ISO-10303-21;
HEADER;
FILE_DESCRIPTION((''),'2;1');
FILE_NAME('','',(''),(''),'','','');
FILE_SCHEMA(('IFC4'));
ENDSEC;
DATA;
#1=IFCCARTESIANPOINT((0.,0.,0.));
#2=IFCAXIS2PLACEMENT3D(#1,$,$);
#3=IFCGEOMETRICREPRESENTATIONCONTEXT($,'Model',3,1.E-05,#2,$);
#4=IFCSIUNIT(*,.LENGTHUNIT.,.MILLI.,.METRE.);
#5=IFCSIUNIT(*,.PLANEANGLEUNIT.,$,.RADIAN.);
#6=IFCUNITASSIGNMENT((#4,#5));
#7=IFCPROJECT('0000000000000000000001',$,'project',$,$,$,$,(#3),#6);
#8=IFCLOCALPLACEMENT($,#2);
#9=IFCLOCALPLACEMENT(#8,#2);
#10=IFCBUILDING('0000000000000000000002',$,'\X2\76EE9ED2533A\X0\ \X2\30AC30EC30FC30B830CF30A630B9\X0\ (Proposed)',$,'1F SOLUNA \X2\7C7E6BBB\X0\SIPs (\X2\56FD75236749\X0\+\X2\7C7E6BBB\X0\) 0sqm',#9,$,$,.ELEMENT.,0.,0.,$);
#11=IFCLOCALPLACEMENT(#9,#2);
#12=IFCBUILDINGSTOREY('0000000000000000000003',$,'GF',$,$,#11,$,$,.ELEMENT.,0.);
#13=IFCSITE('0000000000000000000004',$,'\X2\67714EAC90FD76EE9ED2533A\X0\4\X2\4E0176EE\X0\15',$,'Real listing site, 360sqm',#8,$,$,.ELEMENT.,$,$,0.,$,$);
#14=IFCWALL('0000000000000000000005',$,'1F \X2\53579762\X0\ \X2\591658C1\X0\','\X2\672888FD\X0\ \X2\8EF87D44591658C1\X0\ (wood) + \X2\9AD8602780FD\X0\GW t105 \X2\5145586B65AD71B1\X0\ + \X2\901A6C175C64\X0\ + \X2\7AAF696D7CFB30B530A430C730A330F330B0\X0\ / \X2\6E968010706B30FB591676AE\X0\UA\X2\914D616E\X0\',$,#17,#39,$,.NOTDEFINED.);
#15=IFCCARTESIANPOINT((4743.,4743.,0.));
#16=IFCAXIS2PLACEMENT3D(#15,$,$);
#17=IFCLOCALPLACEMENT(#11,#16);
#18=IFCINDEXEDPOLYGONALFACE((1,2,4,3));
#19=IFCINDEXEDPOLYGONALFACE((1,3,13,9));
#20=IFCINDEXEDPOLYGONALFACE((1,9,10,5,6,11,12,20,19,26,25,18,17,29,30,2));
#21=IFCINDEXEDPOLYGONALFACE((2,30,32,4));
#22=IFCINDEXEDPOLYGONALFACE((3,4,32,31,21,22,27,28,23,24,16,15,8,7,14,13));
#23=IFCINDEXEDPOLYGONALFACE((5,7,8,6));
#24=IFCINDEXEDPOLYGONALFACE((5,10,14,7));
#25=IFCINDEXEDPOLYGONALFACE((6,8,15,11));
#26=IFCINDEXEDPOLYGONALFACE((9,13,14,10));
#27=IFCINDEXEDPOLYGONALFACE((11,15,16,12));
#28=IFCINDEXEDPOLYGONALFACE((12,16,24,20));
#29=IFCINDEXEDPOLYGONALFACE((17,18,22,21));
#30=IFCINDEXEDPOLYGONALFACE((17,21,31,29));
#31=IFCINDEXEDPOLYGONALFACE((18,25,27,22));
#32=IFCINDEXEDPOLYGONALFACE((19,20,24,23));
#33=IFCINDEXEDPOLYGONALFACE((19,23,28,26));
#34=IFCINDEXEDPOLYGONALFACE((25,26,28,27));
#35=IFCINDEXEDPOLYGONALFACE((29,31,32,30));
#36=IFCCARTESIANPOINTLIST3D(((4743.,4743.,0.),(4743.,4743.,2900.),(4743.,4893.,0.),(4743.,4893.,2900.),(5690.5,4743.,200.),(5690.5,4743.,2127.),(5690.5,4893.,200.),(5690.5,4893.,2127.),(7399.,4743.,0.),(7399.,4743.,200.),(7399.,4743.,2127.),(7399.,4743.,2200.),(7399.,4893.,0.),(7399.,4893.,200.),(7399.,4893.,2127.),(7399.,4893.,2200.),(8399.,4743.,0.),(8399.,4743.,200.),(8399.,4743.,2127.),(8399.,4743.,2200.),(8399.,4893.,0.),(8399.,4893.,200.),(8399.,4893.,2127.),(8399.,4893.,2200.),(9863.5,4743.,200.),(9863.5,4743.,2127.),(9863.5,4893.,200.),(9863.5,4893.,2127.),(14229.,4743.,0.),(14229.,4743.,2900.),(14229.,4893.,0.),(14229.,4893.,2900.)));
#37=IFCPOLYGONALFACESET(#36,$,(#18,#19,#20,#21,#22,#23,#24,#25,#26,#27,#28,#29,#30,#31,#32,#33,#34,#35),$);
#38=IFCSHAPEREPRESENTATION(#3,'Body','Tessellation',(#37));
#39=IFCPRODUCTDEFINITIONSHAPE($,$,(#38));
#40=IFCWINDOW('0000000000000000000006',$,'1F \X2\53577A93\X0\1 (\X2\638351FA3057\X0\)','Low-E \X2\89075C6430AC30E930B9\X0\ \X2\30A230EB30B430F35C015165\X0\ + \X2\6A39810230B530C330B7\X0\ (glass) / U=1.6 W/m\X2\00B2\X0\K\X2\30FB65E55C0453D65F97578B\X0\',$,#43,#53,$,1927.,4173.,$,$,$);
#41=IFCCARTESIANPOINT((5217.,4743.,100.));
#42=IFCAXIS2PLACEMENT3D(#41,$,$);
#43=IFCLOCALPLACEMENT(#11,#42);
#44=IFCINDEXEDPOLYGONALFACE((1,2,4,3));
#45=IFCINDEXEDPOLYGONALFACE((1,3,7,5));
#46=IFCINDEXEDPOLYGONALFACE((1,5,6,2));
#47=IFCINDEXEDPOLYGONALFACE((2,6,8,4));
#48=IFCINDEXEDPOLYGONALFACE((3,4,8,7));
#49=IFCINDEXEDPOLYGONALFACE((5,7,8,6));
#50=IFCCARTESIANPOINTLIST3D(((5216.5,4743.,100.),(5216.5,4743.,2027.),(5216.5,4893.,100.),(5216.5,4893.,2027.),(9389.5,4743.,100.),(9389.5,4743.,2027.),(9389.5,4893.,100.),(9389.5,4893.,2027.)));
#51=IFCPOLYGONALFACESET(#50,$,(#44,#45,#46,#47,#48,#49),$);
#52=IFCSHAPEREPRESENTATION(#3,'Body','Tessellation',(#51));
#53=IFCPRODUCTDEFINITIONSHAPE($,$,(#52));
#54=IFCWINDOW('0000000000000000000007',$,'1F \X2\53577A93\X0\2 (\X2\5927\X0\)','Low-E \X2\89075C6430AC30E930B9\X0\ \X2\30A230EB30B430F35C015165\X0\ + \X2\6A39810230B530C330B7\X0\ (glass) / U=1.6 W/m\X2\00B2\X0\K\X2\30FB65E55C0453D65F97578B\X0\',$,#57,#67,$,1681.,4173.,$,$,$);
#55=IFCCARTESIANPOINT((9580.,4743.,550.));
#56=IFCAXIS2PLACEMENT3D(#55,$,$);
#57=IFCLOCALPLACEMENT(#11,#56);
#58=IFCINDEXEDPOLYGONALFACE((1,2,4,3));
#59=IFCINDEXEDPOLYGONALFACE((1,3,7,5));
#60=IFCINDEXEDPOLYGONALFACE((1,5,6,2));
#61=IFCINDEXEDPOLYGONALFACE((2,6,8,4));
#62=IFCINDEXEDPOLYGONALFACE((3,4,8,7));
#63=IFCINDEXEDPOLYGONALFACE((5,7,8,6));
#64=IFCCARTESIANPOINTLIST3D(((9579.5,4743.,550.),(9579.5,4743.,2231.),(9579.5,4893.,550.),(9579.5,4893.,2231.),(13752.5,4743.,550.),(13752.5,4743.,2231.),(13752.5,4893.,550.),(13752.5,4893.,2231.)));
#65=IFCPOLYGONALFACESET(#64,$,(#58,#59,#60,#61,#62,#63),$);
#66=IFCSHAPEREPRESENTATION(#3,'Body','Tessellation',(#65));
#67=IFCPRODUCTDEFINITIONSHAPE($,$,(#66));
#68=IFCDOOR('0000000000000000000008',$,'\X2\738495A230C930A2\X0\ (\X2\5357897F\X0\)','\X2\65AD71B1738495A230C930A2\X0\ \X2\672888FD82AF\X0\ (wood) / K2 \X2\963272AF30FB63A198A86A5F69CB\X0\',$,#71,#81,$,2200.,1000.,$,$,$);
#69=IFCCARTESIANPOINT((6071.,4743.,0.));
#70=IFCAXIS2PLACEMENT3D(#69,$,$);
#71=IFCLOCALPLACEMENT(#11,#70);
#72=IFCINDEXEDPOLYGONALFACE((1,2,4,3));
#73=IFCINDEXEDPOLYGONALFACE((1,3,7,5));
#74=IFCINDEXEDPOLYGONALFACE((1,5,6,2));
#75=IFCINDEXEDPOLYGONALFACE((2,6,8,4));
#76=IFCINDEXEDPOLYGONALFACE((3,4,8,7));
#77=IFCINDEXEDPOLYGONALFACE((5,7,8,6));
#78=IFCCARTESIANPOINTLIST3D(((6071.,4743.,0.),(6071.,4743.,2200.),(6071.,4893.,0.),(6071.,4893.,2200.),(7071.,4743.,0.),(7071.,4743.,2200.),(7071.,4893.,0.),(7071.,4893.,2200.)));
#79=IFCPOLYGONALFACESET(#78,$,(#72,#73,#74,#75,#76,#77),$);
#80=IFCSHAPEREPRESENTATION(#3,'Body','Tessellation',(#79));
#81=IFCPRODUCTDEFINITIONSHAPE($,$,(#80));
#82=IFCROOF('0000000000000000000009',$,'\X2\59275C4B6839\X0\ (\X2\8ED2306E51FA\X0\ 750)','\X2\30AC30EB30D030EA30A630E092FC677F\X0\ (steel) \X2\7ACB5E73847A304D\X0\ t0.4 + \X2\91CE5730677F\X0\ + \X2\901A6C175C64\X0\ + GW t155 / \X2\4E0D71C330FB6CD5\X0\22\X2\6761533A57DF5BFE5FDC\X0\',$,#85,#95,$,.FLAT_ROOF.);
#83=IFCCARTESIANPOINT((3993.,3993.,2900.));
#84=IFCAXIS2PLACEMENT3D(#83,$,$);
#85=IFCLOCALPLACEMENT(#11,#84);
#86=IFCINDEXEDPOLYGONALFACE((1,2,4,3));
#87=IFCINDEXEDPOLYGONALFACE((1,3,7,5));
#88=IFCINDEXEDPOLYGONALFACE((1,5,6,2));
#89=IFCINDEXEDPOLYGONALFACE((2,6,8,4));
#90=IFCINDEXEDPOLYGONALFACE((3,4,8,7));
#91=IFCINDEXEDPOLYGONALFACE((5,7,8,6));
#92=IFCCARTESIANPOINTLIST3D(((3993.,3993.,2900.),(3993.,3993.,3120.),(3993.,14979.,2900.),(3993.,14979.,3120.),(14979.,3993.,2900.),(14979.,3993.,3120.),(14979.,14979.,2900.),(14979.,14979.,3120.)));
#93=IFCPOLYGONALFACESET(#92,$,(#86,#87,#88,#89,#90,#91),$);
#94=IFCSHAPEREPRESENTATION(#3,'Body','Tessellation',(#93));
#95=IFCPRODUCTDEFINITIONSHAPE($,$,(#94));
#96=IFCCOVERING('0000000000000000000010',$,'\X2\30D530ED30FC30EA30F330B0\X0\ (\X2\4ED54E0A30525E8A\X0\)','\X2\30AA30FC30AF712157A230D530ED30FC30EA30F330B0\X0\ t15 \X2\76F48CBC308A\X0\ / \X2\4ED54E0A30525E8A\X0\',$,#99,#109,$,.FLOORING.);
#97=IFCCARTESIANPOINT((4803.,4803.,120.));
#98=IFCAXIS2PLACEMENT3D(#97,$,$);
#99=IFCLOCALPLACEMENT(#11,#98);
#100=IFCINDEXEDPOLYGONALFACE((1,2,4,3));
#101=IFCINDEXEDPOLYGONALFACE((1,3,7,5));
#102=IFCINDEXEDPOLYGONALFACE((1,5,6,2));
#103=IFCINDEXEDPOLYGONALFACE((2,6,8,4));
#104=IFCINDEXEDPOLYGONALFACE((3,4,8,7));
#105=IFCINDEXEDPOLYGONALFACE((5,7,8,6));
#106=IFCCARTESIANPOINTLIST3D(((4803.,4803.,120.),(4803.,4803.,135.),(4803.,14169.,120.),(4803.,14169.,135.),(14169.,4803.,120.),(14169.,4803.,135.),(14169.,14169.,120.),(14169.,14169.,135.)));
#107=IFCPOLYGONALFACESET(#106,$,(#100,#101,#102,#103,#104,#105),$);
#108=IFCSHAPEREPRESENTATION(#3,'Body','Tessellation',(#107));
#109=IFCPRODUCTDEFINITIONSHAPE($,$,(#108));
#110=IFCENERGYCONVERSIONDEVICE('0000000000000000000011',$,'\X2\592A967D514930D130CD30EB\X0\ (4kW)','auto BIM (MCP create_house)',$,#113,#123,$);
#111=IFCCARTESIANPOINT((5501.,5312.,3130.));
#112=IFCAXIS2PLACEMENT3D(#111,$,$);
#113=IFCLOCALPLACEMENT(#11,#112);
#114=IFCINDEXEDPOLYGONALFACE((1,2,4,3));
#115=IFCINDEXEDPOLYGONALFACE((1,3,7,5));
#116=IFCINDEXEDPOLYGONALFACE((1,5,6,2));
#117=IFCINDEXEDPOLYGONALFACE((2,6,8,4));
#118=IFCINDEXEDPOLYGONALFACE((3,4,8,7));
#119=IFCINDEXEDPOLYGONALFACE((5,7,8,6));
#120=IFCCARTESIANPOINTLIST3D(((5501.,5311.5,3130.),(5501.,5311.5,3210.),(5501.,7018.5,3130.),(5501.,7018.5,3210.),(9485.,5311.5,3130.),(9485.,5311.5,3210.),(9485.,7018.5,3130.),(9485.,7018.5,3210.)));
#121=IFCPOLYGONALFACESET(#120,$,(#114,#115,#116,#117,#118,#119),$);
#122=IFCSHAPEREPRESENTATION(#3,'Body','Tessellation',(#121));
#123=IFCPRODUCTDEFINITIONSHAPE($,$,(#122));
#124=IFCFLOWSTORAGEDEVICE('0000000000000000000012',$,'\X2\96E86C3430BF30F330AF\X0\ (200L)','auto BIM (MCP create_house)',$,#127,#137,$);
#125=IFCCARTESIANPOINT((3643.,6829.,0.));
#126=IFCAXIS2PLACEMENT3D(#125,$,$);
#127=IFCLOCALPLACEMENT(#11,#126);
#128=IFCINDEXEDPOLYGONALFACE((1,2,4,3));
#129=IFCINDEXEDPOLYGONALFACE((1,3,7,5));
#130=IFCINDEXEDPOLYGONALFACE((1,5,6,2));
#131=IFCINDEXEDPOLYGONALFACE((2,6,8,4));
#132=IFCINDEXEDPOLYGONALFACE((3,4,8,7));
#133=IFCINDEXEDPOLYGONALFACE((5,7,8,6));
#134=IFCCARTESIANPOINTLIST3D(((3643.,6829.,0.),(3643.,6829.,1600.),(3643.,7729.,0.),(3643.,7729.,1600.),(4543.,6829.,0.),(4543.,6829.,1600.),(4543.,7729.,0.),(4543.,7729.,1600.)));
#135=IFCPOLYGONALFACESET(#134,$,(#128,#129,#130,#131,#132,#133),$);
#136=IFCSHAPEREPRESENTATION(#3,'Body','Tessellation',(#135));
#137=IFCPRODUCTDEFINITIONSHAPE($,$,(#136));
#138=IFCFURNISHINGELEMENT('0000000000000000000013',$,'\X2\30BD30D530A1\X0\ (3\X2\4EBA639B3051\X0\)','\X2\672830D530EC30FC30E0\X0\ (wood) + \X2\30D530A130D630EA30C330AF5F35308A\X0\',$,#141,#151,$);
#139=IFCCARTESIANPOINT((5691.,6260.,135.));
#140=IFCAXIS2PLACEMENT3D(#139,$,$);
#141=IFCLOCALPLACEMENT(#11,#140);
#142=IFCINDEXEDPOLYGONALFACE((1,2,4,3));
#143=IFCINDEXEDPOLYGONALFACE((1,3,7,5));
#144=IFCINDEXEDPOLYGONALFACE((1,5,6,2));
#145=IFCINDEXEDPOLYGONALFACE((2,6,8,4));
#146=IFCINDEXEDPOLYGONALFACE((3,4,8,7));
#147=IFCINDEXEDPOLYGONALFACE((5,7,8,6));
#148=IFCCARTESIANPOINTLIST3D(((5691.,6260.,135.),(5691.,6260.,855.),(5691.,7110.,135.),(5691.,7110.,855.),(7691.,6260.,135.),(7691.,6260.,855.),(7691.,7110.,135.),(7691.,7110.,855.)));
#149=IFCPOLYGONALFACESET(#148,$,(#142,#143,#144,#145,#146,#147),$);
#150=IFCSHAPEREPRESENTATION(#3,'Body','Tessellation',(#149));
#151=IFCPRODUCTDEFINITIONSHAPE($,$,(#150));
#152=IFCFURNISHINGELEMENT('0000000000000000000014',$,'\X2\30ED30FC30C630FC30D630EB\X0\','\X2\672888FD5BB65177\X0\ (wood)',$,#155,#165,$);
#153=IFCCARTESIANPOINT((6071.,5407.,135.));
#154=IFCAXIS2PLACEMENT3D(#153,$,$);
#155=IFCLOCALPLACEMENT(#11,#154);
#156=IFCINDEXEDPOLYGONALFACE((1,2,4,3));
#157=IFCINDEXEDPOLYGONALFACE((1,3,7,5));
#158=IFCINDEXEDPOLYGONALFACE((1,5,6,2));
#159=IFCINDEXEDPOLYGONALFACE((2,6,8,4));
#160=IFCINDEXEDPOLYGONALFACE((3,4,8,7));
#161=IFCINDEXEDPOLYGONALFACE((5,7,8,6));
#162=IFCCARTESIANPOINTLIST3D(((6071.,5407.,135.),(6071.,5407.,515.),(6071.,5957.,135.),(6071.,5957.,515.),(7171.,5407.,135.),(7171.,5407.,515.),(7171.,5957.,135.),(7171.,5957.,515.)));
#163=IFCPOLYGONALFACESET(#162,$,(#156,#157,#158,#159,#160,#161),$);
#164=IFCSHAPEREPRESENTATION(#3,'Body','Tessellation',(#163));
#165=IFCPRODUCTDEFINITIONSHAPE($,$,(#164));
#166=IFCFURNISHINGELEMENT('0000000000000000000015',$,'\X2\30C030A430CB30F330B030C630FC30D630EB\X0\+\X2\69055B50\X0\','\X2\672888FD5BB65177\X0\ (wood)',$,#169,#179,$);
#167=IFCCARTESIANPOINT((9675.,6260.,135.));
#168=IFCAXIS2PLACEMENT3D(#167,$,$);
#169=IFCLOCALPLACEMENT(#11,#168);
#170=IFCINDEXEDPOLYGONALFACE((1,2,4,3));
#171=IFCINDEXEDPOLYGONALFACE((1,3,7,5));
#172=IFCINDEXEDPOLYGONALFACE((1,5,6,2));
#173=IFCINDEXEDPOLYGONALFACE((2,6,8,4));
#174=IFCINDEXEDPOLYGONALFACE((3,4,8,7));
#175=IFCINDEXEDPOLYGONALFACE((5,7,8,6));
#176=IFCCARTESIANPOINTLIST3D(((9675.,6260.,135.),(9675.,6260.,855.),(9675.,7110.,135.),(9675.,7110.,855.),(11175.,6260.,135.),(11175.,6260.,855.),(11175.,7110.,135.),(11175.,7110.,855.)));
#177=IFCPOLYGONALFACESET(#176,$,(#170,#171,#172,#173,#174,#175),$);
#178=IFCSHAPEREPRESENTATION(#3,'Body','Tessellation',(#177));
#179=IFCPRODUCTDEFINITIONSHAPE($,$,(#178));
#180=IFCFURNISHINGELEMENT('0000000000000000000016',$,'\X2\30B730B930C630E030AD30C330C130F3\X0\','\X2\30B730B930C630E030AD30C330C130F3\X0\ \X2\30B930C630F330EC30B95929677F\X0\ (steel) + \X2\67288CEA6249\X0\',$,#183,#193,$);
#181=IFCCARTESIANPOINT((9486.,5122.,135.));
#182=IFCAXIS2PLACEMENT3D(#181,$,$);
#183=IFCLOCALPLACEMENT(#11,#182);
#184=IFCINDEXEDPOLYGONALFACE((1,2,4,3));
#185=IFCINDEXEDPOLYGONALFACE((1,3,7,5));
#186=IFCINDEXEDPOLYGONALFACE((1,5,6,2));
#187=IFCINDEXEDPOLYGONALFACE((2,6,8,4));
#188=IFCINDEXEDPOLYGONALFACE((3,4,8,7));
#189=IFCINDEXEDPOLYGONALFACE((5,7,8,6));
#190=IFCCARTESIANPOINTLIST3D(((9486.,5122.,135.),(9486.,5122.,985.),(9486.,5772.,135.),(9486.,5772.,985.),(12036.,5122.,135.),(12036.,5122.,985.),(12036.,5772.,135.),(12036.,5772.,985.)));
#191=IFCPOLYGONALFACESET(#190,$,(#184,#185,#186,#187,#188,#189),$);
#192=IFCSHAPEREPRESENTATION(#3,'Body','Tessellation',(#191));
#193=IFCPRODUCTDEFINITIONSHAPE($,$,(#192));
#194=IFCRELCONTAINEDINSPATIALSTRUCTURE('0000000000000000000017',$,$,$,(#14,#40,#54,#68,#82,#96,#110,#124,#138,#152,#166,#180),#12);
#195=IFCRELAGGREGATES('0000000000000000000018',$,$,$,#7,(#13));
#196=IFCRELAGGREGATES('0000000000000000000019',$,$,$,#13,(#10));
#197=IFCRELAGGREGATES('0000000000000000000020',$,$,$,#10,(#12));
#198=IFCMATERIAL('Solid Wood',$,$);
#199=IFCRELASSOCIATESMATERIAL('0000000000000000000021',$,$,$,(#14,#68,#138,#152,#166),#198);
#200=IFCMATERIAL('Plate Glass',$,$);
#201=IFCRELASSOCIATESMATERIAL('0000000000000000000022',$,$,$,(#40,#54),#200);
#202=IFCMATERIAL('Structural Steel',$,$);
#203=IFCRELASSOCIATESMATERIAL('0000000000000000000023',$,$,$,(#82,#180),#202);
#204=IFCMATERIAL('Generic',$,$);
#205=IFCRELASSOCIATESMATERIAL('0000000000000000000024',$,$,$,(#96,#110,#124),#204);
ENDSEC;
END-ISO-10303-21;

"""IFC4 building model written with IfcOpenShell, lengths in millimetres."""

from ifc_helpers import new_model, si_unit, frame, frame_2d, origin, place, context, project, spatial, rectangle, extrude, material, element, fill, save


model = new_model("IFC4")

# Units and contexts
model_context = context("Model", 3, precision=1e-05, world=origin())
ifc_project = project(units=[si_unit("LENGTHUNIT", "METRE", prefix="MILLI"), si_unit("PLANEANGLEUNIT", "RADIAN")], contexts=[model_context])

# Site, building, storey
site_placement = place(None, origin())
site = spatial("IfcSite", under=ifc_project, at=site_placement, Name="東京都目黒区4丁目15", ObjectType="Real listing site, 360sqm", CompositionType="ELEMENT", RefElevation=0.0)
building_placement = place(site_placement, origin())
building = spatial("IfcBuilding", under=site, at=building_placement, Name="目黒区 ガレージハウス (Proposed)", ObjectType="1F SOLUNA 籾殻SIPs (国産杉+籾殻) 0sqm", CompositionType="ELEMENT", ElevationOfRefHeight=0.0, ElevationOfTerrain=0.0)
storey_placement = place(building_placement, origin())
storey = spatial("IfcBuildingStorey", under=building, at=storey_placement, Name="GF", CompositionType="ELEMENT", Elevation=0.0)

# Shared definitions
ifc_material_1 = material(Name="Solid Wood")

# Wall, openings, windows, door
wall_1_placement = place(storey_placement, frame((4743.0, 4743.0, 0.0)))
wall_1 = element("IfcWall", 1, at=wall_1_placement, inside=storey, material=ifc_material_1, Name="1F 南面 外壁", Description="木製 軸組外壁 (wood) + 高性能GW t105 充填断熱 + 通気層 + 窯業系サイディング / 準耐火・外皮UA配慮", PredefinedType="NOTDEFINED", context=model_context, shape_type="SweptSolid", body=[
    extrude(rectangle(XDim=9486.0, YDim=150.0, at=frame_2d((4743.0, 75.0))), frame((4743.0, 4743.0, 0.0)), (0.0, 0.0, 1.0), 2900.0),
])
opening_1_placement = place(storey_placement, frame((5217.0, 4743.0, 100.0)))
opening_1 = element("IfcOpeningElement", 2, at=opening_1_placement, cuts=wall_1, PredefinedType="NOTDEFINED", context=model_context, shape_type="SweptSolid", body=[
    extrude(rectangle(XDim=4173.0, YDim=150.0, at=frame_2d((2086.0, 75.0))), frame((5217.0, 4743.0, 100.0)), (0.0, 0.0, 1.0), 1927.0),
])
opening_2_placement = place(storey_placement, frame((9580.0, 4743.0, 550.0)))
opening_2 = element("IfcOpeningElement", 3, at=opening_2_placement, cuts=wall_1, PredefinedType="NOTDEFINED", context=model_context, shape_type="SweptSolid", body=[
    extrude(rectangle(XDim=4173.0, YDim=150.0, at=frame_2d((2086.0, 75.0))), frame((9580.0, 4743.0, 550.0)), (0.0, 0.0, 1.0), 1681.0),
])
opening_3_placement = place(storey_placement, frame((6071.0, 4743.0, 0.0)))
opening_3 = element("IfcOpeningElement", 4, at=opening_3_placement, cuts=wall_1, PredefinedType="NOTDEFINED", context=model_context, shape_type="SweptSolid", body=[
    extrude(rectangle(XDim=1000.0, YDim=150.0, at=frame_2d((500.0, 75.0))), frame((6071.0, 4743.0, 0.0)), (0.0, 0.0, 1.0), 2200.0),
])
ifc_material_2 = material(Name="Plate Glass")
window_1_placement = place(storey_placement, frame((5217.0, 4743.0, 100.0)))
window_1 = element("IfcWindow", 5, at=window_1_placement, inside=storey, material=ifc_material_2, Name="1F 南窓1 (掃出し)", Description="Low-E 複層ガラス アルゴン封入 + 樹脂サッシ (glass) / U=1.6 W/m²K・日射取得型", OverallHeight=1927.0, OverallWidth=4173.0, context=model_context, shape_type="SweptSolid", body=[
    extrude(rectangle(XDim=4173.0, YDim=150.0, at=frame_2d((2086.0, 75.0))), frame((5217.0, 4743.0, 100.0)), (0.0, 0.0, 1.0), 1927.0),
])
fill(opening_1, window_1)
window_2_placement = place(storey_placement, frame((9580.0, 4743.0, 550.0)))
window_2 = element("IfcWindow", 6, at=window_2_placement, inside=storey, material=ifc_material_2, Name="1F 南窓2 (大)", Description="Low-E 複層ガラス アルゴン封入 + 樹脂サッシ (glass) / U=1.6 W/m²K・日射取得型", OverallHeight=1681.0, OverallWidth=4173.0, context=model_context, shape_type="SweptSolid", body=[
    extrude(rectangle(XDim=4173.0, YDim=150.0, at=frame_2d((2086.0, 75.0))), frame((9580.0, 4743.0, 550.0)), (0.0, 0.0, 1.0), 1681.0),
])
fill(opening_2, window_2)
door_placement = place(storey_placement, frame((6071.0, 4743.0, 0.0)))
door = element("IfcDoor", 7, at=door_placement, inside=storey, material=ifc_material_1, Name="玄関ドア (南西)", Description="断熱玄関ドア 木製芯 (wood) / K2 防犯・採風機構", OverallHeight=2200.0, OverallWidth=1000.0, context=model_context, shape_type="SweptSolid", body=[
    extrude(rectangle(XDim=1000.0, YDim=150.0, at=frame_2d((500.0, 75.0))), frame((6071.0, 4743.0, 0.0)), (0.0, 0.0, 1.0), 2200.0),
])
fill(opening_3, door)

# Roof
ifc_material_3 = material(Name="Structural Steel")
roof_placement = place(storey_placement, frame((3993.0, 3993.0, 2900.0)))
element("IfcRoof", 8, at=roof_placement, inside=storey, material=ifc_material_3, Name="大屋根 (軒の出 750)", Description="ガルバリウム鋼板 (steel) 立平葺き t0.4 + 野地板 + 通気層 + GW t155 / 不燃・法22条区域対応", PredefinedType="FLAT_ROOF", context=model_context, shape_type="SweptSolid", body=[
    extrude(rectangle(XDim=10986.0, YDim=10986.0, at=frame_2d((5493.0, 5493.0))), frame((3993.0, 3993.0, 2900.0)), (0.0, 0.0, 1.0), 220.0),
])

# Covering
ifc_material_4 = material(Name="Generic")
covering_placement = place(storey_placement, frame((4803.0, 4803.0, 120.0)))
element("IfcCovering", 9, at=covering_placement, inside=storey, material=ifc_material_4, Name="フローリング (仕上げ床)", Description="オーク無垢フローリング t15 直貼り / 仕上げ床", PredefinedType="FLOORING", context=model_context, shape_type="SweptSolid", body=[
    extrude(rectangle(XDim=9366.0, YDim=9366.0, at=frame_2d((4683.0, 4683.0))), frame((4803.0, 4803.0, 120.0)), (0.0, 0.0, 1.0), 15.0),
])

# Energy conversion device
energy_conversion_device_placement = place(storey_placement, frame((5501.0, 5312.0, 3130.0)))
element("IfcEnergyConversionDevice", 10, at=energy_conversion_device_placement, inside=storey, material=ifc_material_4, Name="太陽光パネル (4kW)", Description="auto BIM (MCP create_house)", context=model_context, shape_type="SweptSolid", body=[
    extrude(rectangle(XDim=3984.0, YDim=1707.0, at=frame_2d((1992.0, 853.0))), frame((5501.0, 5312.0, 3130.0)), (0.0, 0.0, 1.0), 80.0),
])

# Flow storage device
flow_storage_device_placement = place(storey_placement, frame((3643.0, 6829.0, 0.0)))
element("IfcFlowStorageDevice", 11, at=flow_storage_device_placement, inside=storey, material=ifc_material_4, Name="雨水タンク (200L)", Description="auto BIM (MCP create_house)", context=model_context, shape_type="SweptSolid", body=[
    extrude(rectangle(XDim=900.0, YDim=900.0, at=frame_2d((450.0, 450.0))), frame((3643.0, 6829.0, 0.0)), (0.0, 0.0, 1.0), 1600.0),
])

# Furnishing elements
furnishing_1_placement = place(storey_placement, frame((5691.0, 6260.0, 135.0)))
element("IfcFurnishingElement", 12, at=furnishing_1_placement, inside=storey, material=ifc_material_1, Name="ソファ (3人掛け)", Description="木フレーム (wood) + ファブリック張り", context=model_context, shape_type="SweptSolid", body=[
    extrude(rectangle(XDim=2000.0, YDim=850.0, at=frame_2d((1000.0, 425.0))), frame((5691.0, 6260.0, 135.0)), (0.0, 0.0, 1.0), 720.0),
])
furnishing_2_placement = place(storey_placement, frame((6071.0, 5407.0, 135.0)))
element("IfcFurnishingElement", 13, at=furnishing_2_placement, inside=storey, material=ifc_material_1, Name="ローテーブル", Description="木製家具 (wood)", context=model_context, shape_type="SweptSolid", body=[
    extrude(rectangle(XDim=1100.0, YDim=550.0, at=frame_2d((550.0, 275.0))), frame((6071.0, 5407.0, 135.0)), (0.0, 0.0, 1.0), 380.0),
])
furnishing_3_placement = place(storey_placement, frame((9675.0, 6260.0, 135.0)))
element("IfcFurnishingElement", 14, at=furnishing_3_placement, inside=storey, material=ifc_material_1, Name="ダイニングテーブル+椅子", Description="木製家具 (wood)", context=model_context, shape_type="SweptSolid", body=[
    extrude(rectangle(XDim=1500.0, YDim=850.0, at=frame_2d((750.0, 425.0))), frame((9675.0, 6260.0, 135.0)), (0.0, 0.0, 1.0), 720.0),
])
furnishing_4_placement = place(storey_placement, frame((9486.0, 5122.0, 135.0)))
element("IfcFurnishingElement", 15, at=furnishing_4_placement, inside=storey, material=ifc_material_3, Name="システムキッチン", Description="システムキッチン ステンレス天板 (steel) + 木質扉", context=model_context, shape_type="SweptSolid", body=[
    extrude(rectangle(XDim=2550.0, YDim=650.0, at=frame_2d((1275.0, 325.0))), frame((9486.0, 5122.0, 135.0)), (0.0, 0.0, 1.0), 850.0),
])

save(model, "model.ifc")
